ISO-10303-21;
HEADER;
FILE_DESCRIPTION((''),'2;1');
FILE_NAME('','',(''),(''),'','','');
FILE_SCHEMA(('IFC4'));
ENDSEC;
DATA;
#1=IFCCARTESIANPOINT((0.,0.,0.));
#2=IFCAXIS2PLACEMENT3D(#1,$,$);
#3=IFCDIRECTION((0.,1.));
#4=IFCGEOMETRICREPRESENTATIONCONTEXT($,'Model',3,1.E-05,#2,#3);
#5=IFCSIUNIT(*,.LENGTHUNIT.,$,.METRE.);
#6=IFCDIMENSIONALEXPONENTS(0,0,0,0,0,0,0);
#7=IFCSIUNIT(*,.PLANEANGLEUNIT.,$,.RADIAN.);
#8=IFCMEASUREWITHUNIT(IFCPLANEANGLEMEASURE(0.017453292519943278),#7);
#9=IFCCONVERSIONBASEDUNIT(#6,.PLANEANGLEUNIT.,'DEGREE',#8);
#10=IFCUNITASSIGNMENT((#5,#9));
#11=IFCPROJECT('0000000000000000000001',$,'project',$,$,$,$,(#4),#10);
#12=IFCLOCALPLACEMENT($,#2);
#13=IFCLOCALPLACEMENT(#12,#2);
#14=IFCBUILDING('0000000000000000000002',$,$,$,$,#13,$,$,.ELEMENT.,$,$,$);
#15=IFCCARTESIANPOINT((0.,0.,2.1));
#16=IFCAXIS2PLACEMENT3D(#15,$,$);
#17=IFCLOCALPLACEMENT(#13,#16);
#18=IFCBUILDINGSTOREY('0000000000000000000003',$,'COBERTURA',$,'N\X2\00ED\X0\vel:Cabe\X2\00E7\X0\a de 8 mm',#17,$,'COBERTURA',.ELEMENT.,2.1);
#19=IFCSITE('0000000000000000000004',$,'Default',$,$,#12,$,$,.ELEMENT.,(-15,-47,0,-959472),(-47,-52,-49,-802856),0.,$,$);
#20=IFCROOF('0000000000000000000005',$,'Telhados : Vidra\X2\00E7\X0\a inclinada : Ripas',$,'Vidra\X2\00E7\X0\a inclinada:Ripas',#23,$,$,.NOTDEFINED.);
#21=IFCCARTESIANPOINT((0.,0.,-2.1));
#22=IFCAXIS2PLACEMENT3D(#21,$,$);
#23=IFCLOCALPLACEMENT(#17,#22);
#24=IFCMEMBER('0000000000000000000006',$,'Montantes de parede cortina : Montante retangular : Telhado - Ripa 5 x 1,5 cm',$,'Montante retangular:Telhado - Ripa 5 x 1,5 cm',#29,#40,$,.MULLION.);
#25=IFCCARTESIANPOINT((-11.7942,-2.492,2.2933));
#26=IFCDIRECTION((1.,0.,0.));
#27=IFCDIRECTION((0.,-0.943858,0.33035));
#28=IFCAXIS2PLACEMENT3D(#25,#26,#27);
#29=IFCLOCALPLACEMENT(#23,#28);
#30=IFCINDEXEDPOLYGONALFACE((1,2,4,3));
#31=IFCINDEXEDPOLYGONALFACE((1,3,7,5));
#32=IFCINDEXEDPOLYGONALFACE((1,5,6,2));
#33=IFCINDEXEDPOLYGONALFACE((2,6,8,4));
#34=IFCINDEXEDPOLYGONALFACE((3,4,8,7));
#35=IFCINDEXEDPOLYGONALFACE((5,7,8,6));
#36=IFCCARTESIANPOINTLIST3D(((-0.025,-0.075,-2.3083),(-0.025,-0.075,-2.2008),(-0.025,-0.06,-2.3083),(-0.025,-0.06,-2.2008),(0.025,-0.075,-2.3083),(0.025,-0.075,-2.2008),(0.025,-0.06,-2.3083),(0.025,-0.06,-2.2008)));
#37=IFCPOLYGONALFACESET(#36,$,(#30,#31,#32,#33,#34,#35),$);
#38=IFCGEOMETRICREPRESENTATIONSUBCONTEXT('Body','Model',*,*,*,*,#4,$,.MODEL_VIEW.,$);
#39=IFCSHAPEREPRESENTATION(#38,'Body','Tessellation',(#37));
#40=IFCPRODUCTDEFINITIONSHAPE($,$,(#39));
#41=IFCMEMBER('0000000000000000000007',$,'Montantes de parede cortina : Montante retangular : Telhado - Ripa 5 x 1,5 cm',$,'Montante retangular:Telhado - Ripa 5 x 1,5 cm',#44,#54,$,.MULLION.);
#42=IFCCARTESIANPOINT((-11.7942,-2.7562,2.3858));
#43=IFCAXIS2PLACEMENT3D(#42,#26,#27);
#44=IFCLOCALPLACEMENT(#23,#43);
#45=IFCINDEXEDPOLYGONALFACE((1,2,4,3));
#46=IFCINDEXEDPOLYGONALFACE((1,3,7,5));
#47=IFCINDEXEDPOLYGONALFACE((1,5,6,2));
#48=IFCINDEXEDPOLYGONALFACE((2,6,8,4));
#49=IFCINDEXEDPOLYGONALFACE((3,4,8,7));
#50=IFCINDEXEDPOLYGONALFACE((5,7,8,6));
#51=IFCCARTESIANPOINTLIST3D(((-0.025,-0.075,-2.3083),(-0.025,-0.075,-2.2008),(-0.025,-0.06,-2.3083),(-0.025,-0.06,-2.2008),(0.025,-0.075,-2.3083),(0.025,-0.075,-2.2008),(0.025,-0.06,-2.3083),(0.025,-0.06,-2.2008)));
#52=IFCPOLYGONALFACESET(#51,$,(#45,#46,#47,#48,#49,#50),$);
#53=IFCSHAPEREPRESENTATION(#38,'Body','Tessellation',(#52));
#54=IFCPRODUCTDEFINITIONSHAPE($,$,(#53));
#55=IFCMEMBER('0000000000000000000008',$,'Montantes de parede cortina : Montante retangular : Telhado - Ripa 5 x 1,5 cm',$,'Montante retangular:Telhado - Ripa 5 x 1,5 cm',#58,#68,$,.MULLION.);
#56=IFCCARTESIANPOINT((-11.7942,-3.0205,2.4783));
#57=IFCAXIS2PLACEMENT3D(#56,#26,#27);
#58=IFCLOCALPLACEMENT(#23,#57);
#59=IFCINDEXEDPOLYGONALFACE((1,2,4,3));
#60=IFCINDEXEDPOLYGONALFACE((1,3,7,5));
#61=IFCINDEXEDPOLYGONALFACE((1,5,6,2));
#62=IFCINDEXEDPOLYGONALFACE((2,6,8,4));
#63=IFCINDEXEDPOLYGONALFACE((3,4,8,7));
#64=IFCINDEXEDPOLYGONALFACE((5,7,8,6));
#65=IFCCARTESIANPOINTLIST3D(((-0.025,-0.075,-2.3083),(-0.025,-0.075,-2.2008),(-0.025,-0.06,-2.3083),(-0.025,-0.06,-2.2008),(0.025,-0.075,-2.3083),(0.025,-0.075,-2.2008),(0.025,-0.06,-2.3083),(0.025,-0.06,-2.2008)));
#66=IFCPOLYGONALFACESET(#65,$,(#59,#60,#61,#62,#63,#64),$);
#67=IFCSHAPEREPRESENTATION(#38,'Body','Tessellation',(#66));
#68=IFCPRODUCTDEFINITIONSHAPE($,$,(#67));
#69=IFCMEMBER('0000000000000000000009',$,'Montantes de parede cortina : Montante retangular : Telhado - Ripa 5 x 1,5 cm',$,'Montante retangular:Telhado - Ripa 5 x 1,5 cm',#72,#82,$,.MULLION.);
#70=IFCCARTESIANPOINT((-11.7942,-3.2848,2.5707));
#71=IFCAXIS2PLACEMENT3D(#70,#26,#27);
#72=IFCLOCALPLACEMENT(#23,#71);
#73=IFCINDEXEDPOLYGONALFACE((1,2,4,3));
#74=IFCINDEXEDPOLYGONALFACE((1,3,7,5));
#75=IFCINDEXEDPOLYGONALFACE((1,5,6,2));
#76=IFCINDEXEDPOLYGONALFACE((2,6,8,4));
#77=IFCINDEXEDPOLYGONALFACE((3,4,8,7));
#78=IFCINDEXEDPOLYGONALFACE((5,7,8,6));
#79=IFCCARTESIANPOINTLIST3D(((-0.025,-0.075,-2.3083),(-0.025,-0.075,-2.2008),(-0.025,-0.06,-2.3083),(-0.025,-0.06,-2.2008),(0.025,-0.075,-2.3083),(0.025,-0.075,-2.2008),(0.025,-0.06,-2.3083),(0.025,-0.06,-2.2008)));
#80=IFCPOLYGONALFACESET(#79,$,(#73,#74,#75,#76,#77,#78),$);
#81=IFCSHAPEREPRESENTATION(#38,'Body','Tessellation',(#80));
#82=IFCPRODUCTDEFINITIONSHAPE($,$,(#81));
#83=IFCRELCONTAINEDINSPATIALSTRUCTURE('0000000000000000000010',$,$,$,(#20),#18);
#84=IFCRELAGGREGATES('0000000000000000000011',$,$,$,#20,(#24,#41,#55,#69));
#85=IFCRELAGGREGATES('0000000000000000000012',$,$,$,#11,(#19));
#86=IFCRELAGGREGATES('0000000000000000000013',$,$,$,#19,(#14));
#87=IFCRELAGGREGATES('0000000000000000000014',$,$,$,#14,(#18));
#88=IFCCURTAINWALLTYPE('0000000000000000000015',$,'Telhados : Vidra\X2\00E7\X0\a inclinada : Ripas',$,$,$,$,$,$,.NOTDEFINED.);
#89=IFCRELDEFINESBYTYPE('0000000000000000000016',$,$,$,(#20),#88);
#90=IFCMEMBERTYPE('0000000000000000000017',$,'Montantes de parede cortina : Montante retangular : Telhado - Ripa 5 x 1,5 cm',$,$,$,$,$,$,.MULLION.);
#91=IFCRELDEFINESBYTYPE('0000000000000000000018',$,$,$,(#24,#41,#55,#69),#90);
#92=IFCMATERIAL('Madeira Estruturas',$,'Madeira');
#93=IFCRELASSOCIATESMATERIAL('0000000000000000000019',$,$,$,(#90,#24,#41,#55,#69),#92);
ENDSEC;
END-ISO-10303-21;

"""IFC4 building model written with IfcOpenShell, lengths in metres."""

from ifc_helpers import new_model, entity, si_unit, converted_unit, direction, frame, origin, place, context, subcontext, project, spatial, indexed_curve, outline, extrude, source, transform, mapped, material, type_object, type_shapes, element, aggregate, save


model = new_model("IFC4")

# Units and contexts
model_context = context("Model", 3, precision=1e-05, world=origin(), true_north=direction((0.0, 1.0)))
body_context = subcontext(model_context, "Body", "Model", "MODEL_VIEW")
ifc_project = project(units=[si_unit("LENGTHUNIT", "METRE"), converted_unit("PLANEANGLEUNIT", "DEGREE", entity("IfcPlaneAngleMeasure", 0.017453292519943278), si_unit("PLANEANGLEUNIT", "RADIAN"), dimensions=[0, 0, 0, 0, 0, 0, 0])], contexts=[model_context])

# Site, building, storey
site_placement = place(None, origin())
site = spatial("IfcSite", under=ifc_project, at=site_placement, Name="Default", CompositionType="ELEMENT", RefLatitude=(-15, -47, 0, -959472), RefLongitude=(-47, -52, -49, -802856), RefElevation=0.0)
building_placement = place(site_placement, origin())
building = spatial("IfcBuilding", under=site, at=building_placement, CompositionType="ELEMENT")
storey_placement = place(building_placement, frame((0.0, 0.0, 2.1)))
storey = spatial("IfcBuildingStorey", under=building, at=storey_placement, Name="COBERTURA", ObjectType="Nível:Cabeça de 8 mm", LongName="COBERTURA", CompositionType="ELEMENT", Elevation=2.1)

# Roof, members
curtain_wall_type_1 = type_object("IfcCurtainWallType", Name="Telhados : Vidraça inclinada : Ripas", PredefinedType="NOTDEFINED")
roof_1_placement = place(storey_placement, frame((0.0, 0.0, -2.1)))
roof_1 = element("IfcRoof", 1, at=roof_1_placement, inside=storey, type_object=curtain_wall_type_1, Name="Telhados : Vidraça inclinada : Ripas", ObjectType="Vidraça inclinada:Ripas", PredefinedType="NOTDEFINED")
ifc_material_1 = material(Name="Madeira Estruturas", Category="Madeira")
member_type_1 = type_object("IfcMemberType", Name="Montantes de parede cortina : Montante retangular : Telhado - Ripa 5 x 1,5 cm", PredefinedType="MULLION", material=ifc_material_1)
shared_shape_1 = source(origin(), body_context, "Body", "SweptSolid", [
    extrude(outline(indexed_curve([(-0.025, -0.0075), (0.025, -0.0075), (0.025, 0.0075), (-0.025, 0.0075), (-0.025, -0.0075)], self_intersect=False)), frame((0.0, -0.0675, -2.3083), z_axis=(0.0, 0.0, 1.0), x_axis=(-1.0, 0.0, 0.0)), (0.0, 0.0, 1.0), 0.1075),
])
type_shapes(member_type_1, [shared_shape_1])
member_1_placement = place(roof_1_placement, frame((-11.7942, -2.492, 2.2933), z_axis=(1.0, 0.0, 0.0), x_axis=(0.0, -0.943858, 0.33035)))
member_1 = element("IfcMember", 2, at=member_1_placement, type_object=member_type_1, material=ifc_material_1, Name="Montantes de parede cortina : Montante retangular : Telhado - Ripa 5 x 1,5 cm", ObjectType="Montante retangular:Telhado - Ripa 5 x 1,5 cm", PredefinedType="MULLION", context=body_context, shape_type="MappedRepresentation", body=[
    mapped(shared_shape_1, transform((0.0, 0.0, 0.0), scale=1.0)),
])
member_2_placement = place(roof_1_placement, frame((-11.7942, -2.7562, 2.3858), z_axis=(1.0, 0.0, 0.0), x_axis=(0.0, -0.943858, 0.33035)))
member_2 = element("IfcMember", 3, at=member_2_placement, type_object=member_type_1, material=ifc_material_1, Name="Montantes de parede cortina : Montante retangular : Telhado - Ripa 5 x 1,5 cm", ObjectType="Montante retangular:Telhado - Ripa 5 x 1,5 cm", PredefinedType="MULLION", context=body_context, shape_type="MappedRepresentation", body=[
    mapped(shared_shape_1, transform((0.0, 0.0, 0.0), scale=1.0)),
])
member_3_placement = place(roof_1_placement, frame((-11.7942, -3.0205, 2.4783), z_axis=(1.0, 0.0, 0.0), x_axis=(0.0, -0.943858, 0.33035)))
member_3 = element("IfcMember", 4, at=member_3_placement, type_object=member_type_1, material=ifc_material_1, Name="Montantes de parede cortina : Montante retangular : Telhado - Ripa 5 x 1,5 cm", ObjectType="Montante retangular:Telhado - Ripa 5 x 1,5 cm", PredefinedType="MULLION", context=body_context, shape_type="MappedRepresentation", body=[
    mapped(shared_shape_1, transform((0.0, 0.0, 0.0), scale=1.0)),
])
member_4_placement = place(roof_1_placement, frame((-11.7942, -3.2848, 2.5707), z_axis=(1.0, 0.0, 0.0), x_axis=(0.0, -0.943858, 0.33035)))
member_4 = element("IfcMember", 5, at=member_4_placement, type_object=member_type_1, material=ifc_material_1, Name="Montantes de parede cortina : Montante retangular : Telhado - Ripa 5 x 1,5 cm", ObjectType="Montante retangular:Telhado - Ripa 5 x 1,5 cm", PredefinedType="MULLION", context=body_context, shape_type="MappedRepresentation", body=[
    mapped(shared_shape_1, transform((0.0, 0.0, 0.0), scale=1.0)),
])
aggregate(roof_1, [member_1, member_2, member_3, member_4])

save(model, "model.ifc")
